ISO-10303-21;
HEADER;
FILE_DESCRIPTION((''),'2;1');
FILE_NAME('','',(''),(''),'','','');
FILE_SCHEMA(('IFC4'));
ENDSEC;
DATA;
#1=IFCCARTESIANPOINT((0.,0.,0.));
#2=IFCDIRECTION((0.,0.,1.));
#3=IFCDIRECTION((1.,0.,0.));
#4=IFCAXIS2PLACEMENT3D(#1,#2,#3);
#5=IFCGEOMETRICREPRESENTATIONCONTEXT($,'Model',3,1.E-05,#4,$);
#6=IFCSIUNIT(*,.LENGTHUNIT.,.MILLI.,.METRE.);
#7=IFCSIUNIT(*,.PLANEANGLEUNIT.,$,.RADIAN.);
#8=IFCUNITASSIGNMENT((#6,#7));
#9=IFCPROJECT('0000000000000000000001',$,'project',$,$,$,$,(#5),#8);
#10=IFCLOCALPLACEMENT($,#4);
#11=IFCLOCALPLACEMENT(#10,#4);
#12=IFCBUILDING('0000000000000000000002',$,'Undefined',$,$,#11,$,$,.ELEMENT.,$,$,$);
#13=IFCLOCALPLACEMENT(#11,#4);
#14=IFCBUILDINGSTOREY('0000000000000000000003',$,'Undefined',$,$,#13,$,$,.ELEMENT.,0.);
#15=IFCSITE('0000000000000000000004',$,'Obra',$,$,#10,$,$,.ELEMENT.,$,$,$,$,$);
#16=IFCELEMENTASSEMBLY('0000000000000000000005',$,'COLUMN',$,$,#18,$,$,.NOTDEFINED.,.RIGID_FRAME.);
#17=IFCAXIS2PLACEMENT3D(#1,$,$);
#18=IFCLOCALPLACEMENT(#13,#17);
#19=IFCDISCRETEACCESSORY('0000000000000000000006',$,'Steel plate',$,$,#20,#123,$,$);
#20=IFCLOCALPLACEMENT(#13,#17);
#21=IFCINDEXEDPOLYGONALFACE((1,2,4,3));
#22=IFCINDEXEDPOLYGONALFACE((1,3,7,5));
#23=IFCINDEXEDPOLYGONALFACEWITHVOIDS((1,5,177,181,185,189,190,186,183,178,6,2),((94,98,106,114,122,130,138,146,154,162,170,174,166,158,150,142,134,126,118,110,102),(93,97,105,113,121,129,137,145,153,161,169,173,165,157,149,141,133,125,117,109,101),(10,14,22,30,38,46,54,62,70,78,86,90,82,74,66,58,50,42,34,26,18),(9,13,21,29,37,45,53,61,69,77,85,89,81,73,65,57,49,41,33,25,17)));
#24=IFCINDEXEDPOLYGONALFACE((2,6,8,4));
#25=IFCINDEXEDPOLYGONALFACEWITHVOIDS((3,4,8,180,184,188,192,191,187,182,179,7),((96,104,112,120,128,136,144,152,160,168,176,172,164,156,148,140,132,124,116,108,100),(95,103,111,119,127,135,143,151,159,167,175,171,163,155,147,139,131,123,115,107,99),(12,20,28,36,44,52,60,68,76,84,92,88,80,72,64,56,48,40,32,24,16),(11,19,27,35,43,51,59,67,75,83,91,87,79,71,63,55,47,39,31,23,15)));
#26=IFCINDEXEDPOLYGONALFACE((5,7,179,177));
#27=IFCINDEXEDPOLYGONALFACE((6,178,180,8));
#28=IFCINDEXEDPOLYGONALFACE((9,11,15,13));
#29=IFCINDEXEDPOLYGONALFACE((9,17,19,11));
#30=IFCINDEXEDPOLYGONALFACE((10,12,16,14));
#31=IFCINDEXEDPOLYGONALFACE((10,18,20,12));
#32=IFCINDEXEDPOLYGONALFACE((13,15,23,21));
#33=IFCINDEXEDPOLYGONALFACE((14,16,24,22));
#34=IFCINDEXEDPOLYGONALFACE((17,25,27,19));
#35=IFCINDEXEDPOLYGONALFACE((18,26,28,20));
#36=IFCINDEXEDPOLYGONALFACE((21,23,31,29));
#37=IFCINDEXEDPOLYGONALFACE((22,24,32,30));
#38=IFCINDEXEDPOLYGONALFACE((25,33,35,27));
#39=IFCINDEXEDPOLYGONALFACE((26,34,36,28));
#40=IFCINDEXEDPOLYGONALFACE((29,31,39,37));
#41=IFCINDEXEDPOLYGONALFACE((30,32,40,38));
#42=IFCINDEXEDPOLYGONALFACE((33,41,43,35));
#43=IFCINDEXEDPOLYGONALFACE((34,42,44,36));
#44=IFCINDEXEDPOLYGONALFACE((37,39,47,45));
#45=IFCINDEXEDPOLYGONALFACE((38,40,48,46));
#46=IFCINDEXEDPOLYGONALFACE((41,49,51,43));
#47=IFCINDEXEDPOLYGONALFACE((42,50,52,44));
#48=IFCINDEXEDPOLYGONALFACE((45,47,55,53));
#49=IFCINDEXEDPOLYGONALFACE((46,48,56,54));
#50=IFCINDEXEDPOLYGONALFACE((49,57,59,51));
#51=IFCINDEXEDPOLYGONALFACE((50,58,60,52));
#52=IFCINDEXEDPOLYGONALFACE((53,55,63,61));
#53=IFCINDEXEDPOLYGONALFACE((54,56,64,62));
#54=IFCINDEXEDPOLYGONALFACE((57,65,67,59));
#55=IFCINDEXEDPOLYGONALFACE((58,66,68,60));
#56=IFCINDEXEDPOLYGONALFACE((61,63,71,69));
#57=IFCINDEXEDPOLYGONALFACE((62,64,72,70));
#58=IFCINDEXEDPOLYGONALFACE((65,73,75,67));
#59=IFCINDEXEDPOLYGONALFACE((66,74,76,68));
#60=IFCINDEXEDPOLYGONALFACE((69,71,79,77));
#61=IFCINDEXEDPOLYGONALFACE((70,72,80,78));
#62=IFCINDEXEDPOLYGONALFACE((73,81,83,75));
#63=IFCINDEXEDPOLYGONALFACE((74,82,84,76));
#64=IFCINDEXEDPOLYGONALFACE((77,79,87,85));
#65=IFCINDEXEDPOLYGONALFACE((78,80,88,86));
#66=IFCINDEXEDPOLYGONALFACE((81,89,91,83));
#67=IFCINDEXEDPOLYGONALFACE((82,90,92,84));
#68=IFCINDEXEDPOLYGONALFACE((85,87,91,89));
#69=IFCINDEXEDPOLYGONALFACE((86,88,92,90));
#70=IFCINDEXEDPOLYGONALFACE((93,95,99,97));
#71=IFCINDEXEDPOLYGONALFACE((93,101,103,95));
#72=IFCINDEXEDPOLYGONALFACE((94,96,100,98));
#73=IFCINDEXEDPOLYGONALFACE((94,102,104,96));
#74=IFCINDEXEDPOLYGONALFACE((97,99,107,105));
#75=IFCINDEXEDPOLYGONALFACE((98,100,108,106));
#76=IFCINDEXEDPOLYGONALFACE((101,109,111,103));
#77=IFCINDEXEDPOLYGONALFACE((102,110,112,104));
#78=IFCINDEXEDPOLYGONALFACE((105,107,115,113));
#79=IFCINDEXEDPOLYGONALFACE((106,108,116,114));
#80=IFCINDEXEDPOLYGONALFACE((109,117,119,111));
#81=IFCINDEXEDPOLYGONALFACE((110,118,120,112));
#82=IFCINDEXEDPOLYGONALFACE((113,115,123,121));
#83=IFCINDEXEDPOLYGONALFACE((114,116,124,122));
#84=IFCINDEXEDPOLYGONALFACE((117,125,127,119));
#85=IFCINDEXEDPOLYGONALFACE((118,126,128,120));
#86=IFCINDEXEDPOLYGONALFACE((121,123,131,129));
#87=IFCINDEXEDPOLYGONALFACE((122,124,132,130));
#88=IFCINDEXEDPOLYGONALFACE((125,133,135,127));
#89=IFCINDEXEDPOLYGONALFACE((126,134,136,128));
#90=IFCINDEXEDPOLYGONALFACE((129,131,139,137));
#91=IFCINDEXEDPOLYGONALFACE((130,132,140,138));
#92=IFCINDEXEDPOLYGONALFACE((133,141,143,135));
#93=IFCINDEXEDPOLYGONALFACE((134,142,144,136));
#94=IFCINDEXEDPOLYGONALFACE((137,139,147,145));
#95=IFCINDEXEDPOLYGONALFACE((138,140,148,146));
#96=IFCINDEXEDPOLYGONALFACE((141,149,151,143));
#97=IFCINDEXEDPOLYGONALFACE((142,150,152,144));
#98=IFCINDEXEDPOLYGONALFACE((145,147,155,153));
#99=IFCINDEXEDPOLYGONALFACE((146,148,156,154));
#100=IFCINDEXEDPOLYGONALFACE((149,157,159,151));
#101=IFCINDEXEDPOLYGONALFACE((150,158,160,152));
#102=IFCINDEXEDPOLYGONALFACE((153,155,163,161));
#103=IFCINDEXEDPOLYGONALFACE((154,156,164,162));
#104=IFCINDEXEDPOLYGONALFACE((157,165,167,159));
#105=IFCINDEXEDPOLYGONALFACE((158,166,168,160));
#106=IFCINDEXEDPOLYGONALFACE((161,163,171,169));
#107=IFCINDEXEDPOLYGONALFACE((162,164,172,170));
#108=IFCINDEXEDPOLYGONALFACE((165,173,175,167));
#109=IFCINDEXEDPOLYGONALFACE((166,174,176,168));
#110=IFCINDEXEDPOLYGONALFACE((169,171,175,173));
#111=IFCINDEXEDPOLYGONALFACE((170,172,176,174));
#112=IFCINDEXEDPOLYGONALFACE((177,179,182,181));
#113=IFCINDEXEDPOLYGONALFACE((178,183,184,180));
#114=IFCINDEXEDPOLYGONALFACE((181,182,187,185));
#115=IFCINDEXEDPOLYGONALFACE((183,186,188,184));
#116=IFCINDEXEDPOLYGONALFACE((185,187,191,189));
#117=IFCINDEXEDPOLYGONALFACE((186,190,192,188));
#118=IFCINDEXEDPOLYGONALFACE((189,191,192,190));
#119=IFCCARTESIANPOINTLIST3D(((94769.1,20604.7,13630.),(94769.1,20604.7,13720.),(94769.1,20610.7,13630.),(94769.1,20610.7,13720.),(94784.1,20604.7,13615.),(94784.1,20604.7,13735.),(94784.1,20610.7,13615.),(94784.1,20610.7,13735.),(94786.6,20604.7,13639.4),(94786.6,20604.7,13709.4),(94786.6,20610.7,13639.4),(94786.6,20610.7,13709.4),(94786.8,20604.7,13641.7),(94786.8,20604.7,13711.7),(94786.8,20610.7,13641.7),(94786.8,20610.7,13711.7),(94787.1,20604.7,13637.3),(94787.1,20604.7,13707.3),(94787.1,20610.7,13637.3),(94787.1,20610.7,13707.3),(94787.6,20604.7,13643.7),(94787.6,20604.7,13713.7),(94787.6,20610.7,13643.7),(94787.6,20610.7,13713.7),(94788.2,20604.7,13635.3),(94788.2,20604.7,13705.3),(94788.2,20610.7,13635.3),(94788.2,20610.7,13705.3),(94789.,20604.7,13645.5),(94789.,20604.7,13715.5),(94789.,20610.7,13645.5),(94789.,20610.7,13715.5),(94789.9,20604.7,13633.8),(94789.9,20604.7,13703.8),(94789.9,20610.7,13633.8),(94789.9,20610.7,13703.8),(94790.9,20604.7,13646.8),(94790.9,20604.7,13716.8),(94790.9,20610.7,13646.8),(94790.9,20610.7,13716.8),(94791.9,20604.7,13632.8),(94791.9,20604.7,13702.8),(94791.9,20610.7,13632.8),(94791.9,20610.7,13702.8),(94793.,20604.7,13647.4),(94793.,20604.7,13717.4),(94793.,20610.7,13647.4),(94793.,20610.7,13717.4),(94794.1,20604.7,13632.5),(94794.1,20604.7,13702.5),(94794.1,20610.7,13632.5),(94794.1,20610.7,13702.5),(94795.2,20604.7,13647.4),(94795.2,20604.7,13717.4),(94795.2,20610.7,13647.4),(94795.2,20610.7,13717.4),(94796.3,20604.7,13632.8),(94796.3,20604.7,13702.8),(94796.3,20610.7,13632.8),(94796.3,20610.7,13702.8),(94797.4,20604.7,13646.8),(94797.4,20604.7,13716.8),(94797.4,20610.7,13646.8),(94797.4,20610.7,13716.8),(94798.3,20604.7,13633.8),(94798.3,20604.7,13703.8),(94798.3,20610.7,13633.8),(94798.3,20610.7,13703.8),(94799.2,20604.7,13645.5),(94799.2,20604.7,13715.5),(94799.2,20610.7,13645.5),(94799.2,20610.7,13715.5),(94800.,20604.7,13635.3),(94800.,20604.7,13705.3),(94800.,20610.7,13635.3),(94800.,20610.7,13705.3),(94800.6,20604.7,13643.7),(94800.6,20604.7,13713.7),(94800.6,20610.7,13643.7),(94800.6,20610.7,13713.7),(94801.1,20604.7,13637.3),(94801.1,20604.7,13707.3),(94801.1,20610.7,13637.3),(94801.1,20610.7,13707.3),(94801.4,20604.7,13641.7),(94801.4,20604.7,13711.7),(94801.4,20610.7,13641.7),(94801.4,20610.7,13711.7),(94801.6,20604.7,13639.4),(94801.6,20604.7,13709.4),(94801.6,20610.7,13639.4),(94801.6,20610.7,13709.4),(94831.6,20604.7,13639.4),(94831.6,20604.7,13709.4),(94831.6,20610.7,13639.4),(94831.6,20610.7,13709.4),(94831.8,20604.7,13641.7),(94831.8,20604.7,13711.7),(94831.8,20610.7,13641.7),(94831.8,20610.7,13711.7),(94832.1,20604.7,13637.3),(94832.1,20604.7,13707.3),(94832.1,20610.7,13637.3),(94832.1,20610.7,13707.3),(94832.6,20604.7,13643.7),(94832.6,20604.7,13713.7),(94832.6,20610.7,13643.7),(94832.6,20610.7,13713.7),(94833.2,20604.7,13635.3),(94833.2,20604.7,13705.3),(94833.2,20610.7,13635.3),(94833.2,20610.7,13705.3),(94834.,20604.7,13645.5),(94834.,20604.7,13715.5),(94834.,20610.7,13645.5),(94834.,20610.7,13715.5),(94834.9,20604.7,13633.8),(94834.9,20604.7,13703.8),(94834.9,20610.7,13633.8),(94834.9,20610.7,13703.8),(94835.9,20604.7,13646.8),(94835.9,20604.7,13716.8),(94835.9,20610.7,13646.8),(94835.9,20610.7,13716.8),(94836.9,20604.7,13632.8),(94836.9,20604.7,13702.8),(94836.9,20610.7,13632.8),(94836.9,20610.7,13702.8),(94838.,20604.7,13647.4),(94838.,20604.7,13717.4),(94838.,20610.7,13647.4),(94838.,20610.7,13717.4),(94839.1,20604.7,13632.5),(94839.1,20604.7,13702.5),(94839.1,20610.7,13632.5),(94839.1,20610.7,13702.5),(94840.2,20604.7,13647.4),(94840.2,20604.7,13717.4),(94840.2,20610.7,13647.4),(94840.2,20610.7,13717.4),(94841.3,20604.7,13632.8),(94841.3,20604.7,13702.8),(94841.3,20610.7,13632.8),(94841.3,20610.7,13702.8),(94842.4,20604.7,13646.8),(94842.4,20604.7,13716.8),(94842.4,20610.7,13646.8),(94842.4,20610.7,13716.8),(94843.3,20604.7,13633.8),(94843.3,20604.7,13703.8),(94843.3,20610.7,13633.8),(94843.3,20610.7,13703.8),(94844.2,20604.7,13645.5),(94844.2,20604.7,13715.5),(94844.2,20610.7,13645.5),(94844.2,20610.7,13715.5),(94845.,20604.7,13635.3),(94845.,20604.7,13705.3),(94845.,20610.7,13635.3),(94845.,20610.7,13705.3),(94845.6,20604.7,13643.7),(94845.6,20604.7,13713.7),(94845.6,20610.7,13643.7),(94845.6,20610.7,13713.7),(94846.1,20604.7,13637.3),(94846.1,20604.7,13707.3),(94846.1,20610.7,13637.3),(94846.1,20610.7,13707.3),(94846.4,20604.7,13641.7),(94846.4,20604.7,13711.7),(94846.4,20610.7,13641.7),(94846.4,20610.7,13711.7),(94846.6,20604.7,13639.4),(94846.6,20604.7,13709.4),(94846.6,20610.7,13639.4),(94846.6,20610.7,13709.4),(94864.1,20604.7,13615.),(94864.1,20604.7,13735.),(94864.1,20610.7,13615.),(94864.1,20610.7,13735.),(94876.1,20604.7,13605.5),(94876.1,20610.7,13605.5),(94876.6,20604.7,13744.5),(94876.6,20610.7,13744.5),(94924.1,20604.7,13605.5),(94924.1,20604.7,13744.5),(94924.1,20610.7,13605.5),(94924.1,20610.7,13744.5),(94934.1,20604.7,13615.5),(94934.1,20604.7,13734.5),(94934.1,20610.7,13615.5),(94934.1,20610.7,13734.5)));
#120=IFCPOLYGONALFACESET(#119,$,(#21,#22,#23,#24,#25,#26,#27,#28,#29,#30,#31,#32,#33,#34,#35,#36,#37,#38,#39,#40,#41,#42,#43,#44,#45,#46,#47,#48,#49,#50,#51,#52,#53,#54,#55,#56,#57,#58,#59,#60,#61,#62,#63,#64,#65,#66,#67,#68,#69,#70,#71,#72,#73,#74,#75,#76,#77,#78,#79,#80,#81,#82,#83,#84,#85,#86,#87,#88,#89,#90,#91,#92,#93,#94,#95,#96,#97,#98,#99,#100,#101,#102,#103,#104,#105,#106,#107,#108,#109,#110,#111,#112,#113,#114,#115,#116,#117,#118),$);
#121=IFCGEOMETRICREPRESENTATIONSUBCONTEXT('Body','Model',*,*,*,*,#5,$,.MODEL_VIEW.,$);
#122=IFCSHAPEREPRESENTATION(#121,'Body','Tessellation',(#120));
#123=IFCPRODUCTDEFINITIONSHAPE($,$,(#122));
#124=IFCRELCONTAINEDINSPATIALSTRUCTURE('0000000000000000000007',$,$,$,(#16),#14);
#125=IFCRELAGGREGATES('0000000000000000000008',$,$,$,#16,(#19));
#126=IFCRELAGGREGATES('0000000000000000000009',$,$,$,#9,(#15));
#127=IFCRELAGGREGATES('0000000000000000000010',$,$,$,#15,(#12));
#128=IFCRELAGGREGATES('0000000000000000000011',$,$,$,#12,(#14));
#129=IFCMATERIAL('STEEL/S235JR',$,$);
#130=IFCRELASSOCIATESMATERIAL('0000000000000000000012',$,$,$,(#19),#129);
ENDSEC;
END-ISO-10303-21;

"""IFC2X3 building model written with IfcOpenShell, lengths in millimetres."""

from ifc_helpers import new_model, si_unit, frame, origin_with_axes, origin_2d_with_axis, place, context, subcontext, project, spatial, polyline, circle, outline, extrude, source, transform, mapped, material, element, aggregate, save


model = new_model("IFC2X3")

# Units and contexts
model_context = context("Model", 3, precision=1e-05, world=origin_with_axes())
body_context = subcontext(model_context, "Body", "Model", "MODEL_VIEW")
ifc_project = project(units=[si_unit("LENGTHUNIT", "METRE", prefix="MILLI"), si_unit("PLANEANGLEUNIT", "RADIAN")], contexts=[model_context])

# Site, building, storey
site_placement = place(None, origin_with_axes())
site = spatial("IfcSite", under=ifc_project, at=site_placement, Name="Obra", CompositionType="ELEMENT")
building_placement = place(site_placement, origin_with_axes())
building = spatial("IfcBuilding", under=site, at=building_placement, Name="Undefined", CompositionType="ELEMENT")
storey_placement = place(building_placement, origin_with_axes())
storey = spatial("IfcBuildingStorey", under=building, at=storey_placement, Name="Undefined", CompositionType="ELEMENT", Elevation=0.0)

# Element assembly, discrete accessory, opening
assembly_placement = place(storey_placement, origin_with_axes())
assembly = element("IfcElementAssembly", 1, at=assembly_placement, inside=storey, Name="COLUMN", AssemblyPlace="NOTDEFINED", PredefinedType="RIGID_FRAME")
ifc_material_1 = material(Name="STEEL/S235JR")
shared_shape_1 = source(origin_with_axes(), body_context, "Body", "SweptSolid", [
    extrude(circle(Radius=7.5, at=origin_2d_with_axis()), frame((0.0, 2.4, 0.0), z_axis=(0.0, 1.0, 0.0), x_axis=(1.0, 0.0, 0.0)), (0.0, 0.0, 1.0), 6.2),
])
discrete_accessory_1_placement = place(assembly_placement, frame((94934.1, 20607.7, 13615.5), z_axis=(0.0, 1.0, 0.0), x_axis=(-0.707107, 0.0, -0.707107)))
discrete_accessory_1 = element("IfcDiscreteAccessory", 2, at=discrete_accessory_1_placement, material=ifc_material_1, Name="Steel plate", context=body_context, shape_type="SweptSolid", body=[
    extrude(outline(polyline([(0.0, 0.0), (14.1, 0.0), (48.1, 33.9), (49.9, 49.1), (106.4, 105.7), (106.4, 126.9), (42.8, 190.6), (21.6, 190.6), (-35.0, 134.0), (-50.6, 131.9), (-84.1, 98.3), (-84.1, 84.1), (0.0, 0.0)])), frame((0.0, 0.0, -3.0), z_axis=(0.0, 0.0, 1.0), x_axis=(1.0, 0.0, 0.0)), (0.0, 0.0, 1.0), 6.0),
])
opening_1_placement = place(assembly_placement, frame((94816.6, 20613.2, 13710.0), z_axis=(-1.0, 0.0, 0.0), x_axis=(0.0, 0.0, -1.0)))
element("IfcOpeningElement", 3, at=opening_1_placement, cuts=discrete_accessory_1, ObjectType="Opening", context=body_context, shape_type="MappedRepresentation", body=[
    mapped(shared_shape_1, transform((0.0, 0.0, -22.5))),
    mapped(shared_shape_1, transform((70.0, 0.0, -22.5))),
    mapped(shared_shape_1, transform((0.0, 0.0, 22.5))),
    mapped(shared_shape_1, transform((70.0, 0.0, 22.5))),
])
aggregate(assembly, [discrete_accessory_1])

save(model, "model.ifc")
